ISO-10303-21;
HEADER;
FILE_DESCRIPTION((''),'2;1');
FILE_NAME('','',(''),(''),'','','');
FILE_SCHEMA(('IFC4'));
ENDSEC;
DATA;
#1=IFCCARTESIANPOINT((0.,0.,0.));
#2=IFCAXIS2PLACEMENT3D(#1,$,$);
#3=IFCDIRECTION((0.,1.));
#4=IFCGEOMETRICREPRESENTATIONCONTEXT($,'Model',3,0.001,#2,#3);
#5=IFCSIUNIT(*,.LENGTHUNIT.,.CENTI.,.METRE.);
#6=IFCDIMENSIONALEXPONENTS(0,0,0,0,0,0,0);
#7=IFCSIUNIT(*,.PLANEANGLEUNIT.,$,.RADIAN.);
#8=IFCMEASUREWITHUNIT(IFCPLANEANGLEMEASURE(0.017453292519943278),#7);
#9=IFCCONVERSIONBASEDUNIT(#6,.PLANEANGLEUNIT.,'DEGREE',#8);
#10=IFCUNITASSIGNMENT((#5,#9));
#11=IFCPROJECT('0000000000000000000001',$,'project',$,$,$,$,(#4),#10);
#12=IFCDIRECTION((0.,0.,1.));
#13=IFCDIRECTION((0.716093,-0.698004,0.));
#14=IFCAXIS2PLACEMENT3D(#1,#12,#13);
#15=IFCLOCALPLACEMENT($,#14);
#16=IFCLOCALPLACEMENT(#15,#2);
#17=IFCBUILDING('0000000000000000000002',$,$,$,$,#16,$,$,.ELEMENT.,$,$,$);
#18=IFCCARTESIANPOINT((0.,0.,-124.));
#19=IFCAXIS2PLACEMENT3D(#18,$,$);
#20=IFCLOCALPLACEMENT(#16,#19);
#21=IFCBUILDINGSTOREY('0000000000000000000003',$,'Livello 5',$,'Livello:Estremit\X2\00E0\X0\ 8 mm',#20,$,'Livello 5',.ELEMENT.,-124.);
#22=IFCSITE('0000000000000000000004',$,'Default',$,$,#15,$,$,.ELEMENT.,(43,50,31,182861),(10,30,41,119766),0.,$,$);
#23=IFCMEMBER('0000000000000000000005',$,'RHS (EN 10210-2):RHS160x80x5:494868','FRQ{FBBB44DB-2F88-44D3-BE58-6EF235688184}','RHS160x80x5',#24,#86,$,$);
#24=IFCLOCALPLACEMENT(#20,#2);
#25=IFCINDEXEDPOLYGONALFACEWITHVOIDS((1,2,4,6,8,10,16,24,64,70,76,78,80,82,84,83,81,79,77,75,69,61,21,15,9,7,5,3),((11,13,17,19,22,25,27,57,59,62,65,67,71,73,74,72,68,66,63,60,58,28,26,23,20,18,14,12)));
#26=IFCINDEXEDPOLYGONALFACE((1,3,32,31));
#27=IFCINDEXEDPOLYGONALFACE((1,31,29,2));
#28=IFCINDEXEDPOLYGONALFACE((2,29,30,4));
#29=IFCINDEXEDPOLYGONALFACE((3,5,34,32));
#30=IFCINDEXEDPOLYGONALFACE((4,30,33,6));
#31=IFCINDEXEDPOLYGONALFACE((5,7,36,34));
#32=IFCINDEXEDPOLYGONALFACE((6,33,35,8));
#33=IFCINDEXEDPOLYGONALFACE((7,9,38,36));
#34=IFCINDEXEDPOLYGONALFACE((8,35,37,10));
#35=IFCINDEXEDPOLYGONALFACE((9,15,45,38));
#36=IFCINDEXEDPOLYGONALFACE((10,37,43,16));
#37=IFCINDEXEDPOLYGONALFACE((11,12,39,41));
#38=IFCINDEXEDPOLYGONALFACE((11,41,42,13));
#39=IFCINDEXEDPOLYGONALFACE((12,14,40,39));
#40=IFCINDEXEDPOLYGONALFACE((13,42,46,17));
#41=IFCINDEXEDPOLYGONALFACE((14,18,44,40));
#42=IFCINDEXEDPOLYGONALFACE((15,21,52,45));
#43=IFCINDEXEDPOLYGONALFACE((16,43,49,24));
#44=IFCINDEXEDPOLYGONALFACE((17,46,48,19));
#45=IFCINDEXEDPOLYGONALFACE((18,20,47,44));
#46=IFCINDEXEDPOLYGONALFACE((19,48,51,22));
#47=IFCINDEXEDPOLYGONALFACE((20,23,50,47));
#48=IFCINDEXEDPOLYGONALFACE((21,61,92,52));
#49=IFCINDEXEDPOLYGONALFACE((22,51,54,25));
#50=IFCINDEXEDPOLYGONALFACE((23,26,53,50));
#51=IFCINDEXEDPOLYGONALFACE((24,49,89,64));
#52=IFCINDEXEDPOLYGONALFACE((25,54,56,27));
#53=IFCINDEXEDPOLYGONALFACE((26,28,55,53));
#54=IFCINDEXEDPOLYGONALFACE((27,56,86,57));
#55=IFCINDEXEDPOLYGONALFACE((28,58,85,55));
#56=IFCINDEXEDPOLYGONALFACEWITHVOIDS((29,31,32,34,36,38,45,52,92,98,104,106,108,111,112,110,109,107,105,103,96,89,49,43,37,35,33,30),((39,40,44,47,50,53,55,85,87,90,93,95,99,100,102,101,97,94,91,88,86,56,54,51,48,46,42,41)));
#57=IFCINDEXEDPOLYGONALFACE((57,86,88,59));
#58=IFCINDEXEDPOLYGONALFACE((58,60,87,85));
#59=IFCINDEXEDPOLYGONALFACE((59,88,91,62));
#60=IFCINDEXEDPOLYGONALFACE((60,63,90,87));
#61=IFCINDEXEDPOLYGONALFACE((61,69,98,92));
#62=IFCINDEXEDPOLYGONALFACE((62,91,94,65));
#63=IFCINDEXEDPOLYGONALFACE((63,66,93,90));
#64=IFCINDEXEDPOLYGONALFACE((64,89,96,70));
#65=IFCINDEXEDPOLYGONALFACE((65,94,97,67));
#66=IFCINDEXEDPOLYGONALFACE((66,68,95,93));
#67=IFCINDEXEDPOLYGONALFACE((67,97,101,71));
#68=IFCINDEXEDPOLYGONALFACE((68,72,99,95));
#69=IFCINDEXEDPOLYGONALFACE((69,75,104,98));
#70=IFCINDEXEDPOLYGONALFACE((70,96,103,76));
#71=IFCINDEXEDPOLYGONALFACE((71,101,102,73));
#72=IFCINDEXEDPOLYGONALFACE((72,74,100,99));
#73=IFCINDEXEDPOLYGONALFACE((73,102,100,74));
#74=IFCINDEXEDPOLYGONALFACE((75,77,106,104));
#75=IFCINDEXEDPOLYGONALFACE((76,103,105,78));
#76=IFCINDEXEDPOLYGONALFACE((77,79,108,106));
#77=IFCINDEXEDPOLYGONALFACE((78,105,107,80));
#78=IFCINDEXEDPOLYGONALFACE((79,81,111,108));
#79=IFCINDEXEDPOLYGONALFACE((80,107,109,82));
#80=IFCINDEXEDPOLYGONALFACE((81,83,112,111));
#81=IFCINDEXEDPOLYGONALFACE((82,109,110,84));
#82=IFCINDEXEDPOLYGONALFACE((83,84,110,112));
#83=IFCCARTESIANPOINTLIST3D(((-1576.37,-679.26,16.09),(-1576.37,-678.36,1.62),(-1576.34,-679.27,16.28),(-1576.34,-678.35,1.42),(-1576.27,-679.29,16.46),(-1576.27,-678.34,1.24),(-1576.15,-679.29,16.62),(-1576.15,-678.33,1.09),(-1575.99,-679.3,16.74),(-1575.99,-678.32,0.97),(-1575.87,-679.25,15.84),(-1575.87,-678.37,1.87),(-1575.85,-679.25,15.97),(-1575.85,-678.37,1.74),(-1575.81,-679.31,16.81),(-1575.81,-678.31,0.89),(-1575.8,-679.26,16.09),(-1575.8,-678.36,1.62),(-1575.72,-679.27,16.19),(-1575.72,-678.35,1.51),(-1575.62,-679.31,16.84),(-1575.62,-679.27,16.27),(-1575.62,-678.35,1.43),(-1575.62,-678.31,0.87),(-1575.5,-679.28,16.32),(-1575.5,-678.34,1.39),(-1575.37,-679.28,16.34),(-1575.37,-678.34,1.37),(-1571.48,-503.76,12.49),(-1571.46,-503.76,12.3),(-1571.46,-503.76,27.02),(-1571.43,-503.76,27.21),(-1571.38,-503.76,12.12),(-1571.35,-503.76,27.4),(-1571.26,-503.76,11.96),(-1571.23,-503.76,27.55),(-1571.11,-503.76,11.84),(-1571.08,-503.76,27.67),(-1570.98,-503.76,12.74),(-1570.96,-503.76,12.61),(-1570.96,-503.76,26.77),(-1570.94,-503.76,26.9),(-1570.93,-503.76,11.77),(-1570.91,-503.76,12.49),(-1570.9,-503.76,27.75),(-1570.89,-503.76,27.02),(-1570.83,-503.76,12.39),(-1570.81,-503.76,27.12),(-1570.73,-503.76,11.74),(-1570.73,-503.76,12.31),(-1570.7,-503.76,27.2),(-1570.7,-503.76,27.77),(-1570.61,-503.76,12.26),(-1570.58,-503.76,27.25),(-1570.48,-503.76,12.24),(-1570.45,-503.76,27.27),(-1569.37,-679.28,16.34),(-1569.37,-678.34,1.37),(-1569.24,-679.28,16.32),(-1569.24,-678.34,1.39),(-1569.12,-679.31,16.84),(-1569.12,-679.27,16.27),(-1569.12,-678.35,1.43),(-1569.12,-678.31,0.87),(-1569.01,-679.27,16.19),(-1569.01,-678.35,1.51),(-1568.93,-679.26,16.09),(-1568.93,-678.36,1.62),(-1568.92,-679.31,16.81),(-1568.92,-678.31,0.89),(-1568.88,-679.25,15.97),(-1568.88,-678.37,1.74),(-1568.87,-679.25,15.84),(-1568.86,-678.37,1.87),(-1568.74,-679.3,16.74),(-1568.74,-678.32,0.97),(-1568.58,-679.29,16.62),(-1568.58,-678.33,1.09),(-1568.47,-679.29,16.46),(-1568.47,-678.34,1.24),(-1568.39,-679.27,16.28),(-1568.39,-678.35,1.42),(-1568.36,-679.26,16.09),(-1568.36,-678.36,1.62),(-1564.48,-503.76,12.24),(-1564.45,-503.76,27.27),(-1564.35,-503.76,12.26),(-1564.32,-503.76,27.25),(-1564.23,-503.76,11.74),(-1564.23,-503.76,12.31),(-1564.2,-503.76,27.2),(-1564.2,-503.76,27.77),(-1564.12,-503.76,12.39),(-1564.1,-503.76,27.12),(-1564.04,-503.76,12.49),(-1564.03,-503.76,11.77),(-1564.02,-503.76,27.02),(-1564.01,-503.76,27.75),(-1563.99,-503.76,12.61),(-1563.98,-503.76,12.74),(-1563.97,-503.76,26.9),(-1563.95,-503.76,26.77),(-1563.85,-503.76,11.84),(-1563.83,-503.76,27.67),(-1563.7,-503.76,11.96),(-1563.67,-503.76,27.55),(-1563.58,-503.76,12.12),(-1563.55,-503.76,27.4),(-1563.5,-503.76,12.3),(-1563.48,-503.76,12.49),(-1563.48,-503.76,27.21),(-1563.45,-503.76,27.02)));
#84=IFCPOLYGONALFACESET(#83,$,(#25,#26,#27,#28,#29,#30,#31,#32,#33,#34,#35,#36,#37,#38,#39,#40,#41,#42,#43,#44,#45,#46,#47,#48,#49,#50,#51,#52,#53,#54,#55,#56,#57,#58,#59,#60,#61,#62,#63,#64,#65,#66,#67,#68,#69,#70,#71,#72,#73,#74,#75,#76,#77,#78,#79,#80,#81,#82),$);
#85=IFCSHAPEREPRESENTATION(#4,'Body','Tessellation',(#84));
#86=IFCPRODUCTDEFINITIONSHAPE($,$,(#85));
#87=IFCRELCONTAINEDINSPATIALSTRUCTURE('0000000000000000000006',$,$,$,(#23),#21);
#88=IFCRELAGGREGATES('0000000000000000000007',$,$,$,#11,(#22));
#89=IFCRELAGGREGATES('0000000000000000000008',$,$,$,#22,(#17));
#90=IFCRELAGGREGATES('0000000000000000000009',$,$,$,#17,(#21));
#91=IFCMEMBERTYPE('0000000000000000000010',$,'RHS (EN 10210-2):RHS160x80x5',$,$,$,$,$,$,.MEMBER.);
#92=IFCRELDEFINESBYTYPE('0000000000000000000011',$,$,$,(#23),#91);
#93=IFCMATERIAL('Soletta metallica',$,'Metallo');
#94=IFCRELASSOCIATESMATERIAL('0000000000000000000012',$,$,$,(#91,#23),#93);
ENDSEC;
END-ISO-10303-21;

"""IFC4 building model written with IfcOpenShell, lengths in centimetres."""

from ifc_helpers import new_model, entity, si_unit, converted_unit, direction, frame, origin, origin_2d, place, context, project, spatial, hollow_rectangle, extrude, clip, halfspace, material, type_object, element, save


model = new_model("IFC4")

# Units and contexts
model_context = context("Model", 3, precision=0.001, world=origin(), true_north=direction((0.0, 1.0)))
ifc_project = project(units=[si_unit("LENGTHUNIT", "METRE", prefix="CENTI"), converted_unit("PLANEANGLEUNIT", "DEGREE", entity("IfcPlaneAngleMeasure", 0.017453292519943278), si_unit("PLANEANGLEUNIT", "RADIAN"), dimensions=[0, 0, 0, 0, 0, 0, 0])], contexts=[model_context])

# Site, building, storey
site_placement = place(None, frame((0.0, 0.0, 0.0), z_axis=(0.0, 0.0, 1.0), x_axis=(0.716093, -0.698004, 0.0)))
site = spatial("IfcSite", under=ifc_project, at=site_placement, Name="Default", CompositionType="ELEMENT", RefLatitude=(43, 50, 31, 182861), RefLongitude=(10, 30, 41, 119766), RefElevation=0.0)
building_placement = place(site_placement, origin())
building = spatial("IfcBuilding", under=site, at=building_placement, CompositionType="ELEMENT")
storey_placement = place(building_placement, frame((0.0, 0.0, -124.0)))
storey = spatial("IfcBuildingStorey", under=building, at=storey_placement, Name="Livello 5", ObjectType="Livello:Estremità 8 mm", LongName="Livello 5", CompositionType="ELEMENT", Elevation=-124.0)

# Shared definitions
ifc_material_1 = material(Name="Soletta metallica", Category="Metallo")

# Member
member_type_1 = type_object("IfcMemberType", Name="RHS (EN 10210-2):RHS160x80x5", PredefinedType="MEMBER", material=ifc_material_1)
member_1_placement = place(storey_placement, frame((-1573.45, -717.68, 6.43), z_axis=(-0.027926, -0.997677, -0.062135), x_axis=(0.99961, -0.027872, -0.001736)))
element("IfcMember", 1, at=member_1_placement, inside=storey, type_object=member_type_1, material=ifc_material_1, Name="RHS (EN 10210-2):RHS160x80x5:494868", Description="FRQ{FBBB44DB-2F88-44D3-BE58-6EF235688184}", ObjectType="RHS160x80x5", context=model_context, shape_type="Clipping", body=[
    clip(clip(extrude(hollow_rectangle(XDim=8.0, YDim=16.0, WallThickness=0.5, InnerFilletRadius=0.5, OuterFilletRadius=0.75, at=origin_2d()), origin(), (0.0, 0.0, -1.0), 242.93), halfspace(frame((1566.85, 101.3, -264.68), z_axis=(0.02798, 0.062159, 0.997674), x_axis=(0.999608, -0.00174, -0.027926)), True)), halfspace(frame((1571.88, 69.92, -82.86), z_axis=(-0.027926, 0.000109, -0.99961), x_axis=(-0.999608, 0.00174, 0.027926)), True)),
])

save(model, "model.ifc")
